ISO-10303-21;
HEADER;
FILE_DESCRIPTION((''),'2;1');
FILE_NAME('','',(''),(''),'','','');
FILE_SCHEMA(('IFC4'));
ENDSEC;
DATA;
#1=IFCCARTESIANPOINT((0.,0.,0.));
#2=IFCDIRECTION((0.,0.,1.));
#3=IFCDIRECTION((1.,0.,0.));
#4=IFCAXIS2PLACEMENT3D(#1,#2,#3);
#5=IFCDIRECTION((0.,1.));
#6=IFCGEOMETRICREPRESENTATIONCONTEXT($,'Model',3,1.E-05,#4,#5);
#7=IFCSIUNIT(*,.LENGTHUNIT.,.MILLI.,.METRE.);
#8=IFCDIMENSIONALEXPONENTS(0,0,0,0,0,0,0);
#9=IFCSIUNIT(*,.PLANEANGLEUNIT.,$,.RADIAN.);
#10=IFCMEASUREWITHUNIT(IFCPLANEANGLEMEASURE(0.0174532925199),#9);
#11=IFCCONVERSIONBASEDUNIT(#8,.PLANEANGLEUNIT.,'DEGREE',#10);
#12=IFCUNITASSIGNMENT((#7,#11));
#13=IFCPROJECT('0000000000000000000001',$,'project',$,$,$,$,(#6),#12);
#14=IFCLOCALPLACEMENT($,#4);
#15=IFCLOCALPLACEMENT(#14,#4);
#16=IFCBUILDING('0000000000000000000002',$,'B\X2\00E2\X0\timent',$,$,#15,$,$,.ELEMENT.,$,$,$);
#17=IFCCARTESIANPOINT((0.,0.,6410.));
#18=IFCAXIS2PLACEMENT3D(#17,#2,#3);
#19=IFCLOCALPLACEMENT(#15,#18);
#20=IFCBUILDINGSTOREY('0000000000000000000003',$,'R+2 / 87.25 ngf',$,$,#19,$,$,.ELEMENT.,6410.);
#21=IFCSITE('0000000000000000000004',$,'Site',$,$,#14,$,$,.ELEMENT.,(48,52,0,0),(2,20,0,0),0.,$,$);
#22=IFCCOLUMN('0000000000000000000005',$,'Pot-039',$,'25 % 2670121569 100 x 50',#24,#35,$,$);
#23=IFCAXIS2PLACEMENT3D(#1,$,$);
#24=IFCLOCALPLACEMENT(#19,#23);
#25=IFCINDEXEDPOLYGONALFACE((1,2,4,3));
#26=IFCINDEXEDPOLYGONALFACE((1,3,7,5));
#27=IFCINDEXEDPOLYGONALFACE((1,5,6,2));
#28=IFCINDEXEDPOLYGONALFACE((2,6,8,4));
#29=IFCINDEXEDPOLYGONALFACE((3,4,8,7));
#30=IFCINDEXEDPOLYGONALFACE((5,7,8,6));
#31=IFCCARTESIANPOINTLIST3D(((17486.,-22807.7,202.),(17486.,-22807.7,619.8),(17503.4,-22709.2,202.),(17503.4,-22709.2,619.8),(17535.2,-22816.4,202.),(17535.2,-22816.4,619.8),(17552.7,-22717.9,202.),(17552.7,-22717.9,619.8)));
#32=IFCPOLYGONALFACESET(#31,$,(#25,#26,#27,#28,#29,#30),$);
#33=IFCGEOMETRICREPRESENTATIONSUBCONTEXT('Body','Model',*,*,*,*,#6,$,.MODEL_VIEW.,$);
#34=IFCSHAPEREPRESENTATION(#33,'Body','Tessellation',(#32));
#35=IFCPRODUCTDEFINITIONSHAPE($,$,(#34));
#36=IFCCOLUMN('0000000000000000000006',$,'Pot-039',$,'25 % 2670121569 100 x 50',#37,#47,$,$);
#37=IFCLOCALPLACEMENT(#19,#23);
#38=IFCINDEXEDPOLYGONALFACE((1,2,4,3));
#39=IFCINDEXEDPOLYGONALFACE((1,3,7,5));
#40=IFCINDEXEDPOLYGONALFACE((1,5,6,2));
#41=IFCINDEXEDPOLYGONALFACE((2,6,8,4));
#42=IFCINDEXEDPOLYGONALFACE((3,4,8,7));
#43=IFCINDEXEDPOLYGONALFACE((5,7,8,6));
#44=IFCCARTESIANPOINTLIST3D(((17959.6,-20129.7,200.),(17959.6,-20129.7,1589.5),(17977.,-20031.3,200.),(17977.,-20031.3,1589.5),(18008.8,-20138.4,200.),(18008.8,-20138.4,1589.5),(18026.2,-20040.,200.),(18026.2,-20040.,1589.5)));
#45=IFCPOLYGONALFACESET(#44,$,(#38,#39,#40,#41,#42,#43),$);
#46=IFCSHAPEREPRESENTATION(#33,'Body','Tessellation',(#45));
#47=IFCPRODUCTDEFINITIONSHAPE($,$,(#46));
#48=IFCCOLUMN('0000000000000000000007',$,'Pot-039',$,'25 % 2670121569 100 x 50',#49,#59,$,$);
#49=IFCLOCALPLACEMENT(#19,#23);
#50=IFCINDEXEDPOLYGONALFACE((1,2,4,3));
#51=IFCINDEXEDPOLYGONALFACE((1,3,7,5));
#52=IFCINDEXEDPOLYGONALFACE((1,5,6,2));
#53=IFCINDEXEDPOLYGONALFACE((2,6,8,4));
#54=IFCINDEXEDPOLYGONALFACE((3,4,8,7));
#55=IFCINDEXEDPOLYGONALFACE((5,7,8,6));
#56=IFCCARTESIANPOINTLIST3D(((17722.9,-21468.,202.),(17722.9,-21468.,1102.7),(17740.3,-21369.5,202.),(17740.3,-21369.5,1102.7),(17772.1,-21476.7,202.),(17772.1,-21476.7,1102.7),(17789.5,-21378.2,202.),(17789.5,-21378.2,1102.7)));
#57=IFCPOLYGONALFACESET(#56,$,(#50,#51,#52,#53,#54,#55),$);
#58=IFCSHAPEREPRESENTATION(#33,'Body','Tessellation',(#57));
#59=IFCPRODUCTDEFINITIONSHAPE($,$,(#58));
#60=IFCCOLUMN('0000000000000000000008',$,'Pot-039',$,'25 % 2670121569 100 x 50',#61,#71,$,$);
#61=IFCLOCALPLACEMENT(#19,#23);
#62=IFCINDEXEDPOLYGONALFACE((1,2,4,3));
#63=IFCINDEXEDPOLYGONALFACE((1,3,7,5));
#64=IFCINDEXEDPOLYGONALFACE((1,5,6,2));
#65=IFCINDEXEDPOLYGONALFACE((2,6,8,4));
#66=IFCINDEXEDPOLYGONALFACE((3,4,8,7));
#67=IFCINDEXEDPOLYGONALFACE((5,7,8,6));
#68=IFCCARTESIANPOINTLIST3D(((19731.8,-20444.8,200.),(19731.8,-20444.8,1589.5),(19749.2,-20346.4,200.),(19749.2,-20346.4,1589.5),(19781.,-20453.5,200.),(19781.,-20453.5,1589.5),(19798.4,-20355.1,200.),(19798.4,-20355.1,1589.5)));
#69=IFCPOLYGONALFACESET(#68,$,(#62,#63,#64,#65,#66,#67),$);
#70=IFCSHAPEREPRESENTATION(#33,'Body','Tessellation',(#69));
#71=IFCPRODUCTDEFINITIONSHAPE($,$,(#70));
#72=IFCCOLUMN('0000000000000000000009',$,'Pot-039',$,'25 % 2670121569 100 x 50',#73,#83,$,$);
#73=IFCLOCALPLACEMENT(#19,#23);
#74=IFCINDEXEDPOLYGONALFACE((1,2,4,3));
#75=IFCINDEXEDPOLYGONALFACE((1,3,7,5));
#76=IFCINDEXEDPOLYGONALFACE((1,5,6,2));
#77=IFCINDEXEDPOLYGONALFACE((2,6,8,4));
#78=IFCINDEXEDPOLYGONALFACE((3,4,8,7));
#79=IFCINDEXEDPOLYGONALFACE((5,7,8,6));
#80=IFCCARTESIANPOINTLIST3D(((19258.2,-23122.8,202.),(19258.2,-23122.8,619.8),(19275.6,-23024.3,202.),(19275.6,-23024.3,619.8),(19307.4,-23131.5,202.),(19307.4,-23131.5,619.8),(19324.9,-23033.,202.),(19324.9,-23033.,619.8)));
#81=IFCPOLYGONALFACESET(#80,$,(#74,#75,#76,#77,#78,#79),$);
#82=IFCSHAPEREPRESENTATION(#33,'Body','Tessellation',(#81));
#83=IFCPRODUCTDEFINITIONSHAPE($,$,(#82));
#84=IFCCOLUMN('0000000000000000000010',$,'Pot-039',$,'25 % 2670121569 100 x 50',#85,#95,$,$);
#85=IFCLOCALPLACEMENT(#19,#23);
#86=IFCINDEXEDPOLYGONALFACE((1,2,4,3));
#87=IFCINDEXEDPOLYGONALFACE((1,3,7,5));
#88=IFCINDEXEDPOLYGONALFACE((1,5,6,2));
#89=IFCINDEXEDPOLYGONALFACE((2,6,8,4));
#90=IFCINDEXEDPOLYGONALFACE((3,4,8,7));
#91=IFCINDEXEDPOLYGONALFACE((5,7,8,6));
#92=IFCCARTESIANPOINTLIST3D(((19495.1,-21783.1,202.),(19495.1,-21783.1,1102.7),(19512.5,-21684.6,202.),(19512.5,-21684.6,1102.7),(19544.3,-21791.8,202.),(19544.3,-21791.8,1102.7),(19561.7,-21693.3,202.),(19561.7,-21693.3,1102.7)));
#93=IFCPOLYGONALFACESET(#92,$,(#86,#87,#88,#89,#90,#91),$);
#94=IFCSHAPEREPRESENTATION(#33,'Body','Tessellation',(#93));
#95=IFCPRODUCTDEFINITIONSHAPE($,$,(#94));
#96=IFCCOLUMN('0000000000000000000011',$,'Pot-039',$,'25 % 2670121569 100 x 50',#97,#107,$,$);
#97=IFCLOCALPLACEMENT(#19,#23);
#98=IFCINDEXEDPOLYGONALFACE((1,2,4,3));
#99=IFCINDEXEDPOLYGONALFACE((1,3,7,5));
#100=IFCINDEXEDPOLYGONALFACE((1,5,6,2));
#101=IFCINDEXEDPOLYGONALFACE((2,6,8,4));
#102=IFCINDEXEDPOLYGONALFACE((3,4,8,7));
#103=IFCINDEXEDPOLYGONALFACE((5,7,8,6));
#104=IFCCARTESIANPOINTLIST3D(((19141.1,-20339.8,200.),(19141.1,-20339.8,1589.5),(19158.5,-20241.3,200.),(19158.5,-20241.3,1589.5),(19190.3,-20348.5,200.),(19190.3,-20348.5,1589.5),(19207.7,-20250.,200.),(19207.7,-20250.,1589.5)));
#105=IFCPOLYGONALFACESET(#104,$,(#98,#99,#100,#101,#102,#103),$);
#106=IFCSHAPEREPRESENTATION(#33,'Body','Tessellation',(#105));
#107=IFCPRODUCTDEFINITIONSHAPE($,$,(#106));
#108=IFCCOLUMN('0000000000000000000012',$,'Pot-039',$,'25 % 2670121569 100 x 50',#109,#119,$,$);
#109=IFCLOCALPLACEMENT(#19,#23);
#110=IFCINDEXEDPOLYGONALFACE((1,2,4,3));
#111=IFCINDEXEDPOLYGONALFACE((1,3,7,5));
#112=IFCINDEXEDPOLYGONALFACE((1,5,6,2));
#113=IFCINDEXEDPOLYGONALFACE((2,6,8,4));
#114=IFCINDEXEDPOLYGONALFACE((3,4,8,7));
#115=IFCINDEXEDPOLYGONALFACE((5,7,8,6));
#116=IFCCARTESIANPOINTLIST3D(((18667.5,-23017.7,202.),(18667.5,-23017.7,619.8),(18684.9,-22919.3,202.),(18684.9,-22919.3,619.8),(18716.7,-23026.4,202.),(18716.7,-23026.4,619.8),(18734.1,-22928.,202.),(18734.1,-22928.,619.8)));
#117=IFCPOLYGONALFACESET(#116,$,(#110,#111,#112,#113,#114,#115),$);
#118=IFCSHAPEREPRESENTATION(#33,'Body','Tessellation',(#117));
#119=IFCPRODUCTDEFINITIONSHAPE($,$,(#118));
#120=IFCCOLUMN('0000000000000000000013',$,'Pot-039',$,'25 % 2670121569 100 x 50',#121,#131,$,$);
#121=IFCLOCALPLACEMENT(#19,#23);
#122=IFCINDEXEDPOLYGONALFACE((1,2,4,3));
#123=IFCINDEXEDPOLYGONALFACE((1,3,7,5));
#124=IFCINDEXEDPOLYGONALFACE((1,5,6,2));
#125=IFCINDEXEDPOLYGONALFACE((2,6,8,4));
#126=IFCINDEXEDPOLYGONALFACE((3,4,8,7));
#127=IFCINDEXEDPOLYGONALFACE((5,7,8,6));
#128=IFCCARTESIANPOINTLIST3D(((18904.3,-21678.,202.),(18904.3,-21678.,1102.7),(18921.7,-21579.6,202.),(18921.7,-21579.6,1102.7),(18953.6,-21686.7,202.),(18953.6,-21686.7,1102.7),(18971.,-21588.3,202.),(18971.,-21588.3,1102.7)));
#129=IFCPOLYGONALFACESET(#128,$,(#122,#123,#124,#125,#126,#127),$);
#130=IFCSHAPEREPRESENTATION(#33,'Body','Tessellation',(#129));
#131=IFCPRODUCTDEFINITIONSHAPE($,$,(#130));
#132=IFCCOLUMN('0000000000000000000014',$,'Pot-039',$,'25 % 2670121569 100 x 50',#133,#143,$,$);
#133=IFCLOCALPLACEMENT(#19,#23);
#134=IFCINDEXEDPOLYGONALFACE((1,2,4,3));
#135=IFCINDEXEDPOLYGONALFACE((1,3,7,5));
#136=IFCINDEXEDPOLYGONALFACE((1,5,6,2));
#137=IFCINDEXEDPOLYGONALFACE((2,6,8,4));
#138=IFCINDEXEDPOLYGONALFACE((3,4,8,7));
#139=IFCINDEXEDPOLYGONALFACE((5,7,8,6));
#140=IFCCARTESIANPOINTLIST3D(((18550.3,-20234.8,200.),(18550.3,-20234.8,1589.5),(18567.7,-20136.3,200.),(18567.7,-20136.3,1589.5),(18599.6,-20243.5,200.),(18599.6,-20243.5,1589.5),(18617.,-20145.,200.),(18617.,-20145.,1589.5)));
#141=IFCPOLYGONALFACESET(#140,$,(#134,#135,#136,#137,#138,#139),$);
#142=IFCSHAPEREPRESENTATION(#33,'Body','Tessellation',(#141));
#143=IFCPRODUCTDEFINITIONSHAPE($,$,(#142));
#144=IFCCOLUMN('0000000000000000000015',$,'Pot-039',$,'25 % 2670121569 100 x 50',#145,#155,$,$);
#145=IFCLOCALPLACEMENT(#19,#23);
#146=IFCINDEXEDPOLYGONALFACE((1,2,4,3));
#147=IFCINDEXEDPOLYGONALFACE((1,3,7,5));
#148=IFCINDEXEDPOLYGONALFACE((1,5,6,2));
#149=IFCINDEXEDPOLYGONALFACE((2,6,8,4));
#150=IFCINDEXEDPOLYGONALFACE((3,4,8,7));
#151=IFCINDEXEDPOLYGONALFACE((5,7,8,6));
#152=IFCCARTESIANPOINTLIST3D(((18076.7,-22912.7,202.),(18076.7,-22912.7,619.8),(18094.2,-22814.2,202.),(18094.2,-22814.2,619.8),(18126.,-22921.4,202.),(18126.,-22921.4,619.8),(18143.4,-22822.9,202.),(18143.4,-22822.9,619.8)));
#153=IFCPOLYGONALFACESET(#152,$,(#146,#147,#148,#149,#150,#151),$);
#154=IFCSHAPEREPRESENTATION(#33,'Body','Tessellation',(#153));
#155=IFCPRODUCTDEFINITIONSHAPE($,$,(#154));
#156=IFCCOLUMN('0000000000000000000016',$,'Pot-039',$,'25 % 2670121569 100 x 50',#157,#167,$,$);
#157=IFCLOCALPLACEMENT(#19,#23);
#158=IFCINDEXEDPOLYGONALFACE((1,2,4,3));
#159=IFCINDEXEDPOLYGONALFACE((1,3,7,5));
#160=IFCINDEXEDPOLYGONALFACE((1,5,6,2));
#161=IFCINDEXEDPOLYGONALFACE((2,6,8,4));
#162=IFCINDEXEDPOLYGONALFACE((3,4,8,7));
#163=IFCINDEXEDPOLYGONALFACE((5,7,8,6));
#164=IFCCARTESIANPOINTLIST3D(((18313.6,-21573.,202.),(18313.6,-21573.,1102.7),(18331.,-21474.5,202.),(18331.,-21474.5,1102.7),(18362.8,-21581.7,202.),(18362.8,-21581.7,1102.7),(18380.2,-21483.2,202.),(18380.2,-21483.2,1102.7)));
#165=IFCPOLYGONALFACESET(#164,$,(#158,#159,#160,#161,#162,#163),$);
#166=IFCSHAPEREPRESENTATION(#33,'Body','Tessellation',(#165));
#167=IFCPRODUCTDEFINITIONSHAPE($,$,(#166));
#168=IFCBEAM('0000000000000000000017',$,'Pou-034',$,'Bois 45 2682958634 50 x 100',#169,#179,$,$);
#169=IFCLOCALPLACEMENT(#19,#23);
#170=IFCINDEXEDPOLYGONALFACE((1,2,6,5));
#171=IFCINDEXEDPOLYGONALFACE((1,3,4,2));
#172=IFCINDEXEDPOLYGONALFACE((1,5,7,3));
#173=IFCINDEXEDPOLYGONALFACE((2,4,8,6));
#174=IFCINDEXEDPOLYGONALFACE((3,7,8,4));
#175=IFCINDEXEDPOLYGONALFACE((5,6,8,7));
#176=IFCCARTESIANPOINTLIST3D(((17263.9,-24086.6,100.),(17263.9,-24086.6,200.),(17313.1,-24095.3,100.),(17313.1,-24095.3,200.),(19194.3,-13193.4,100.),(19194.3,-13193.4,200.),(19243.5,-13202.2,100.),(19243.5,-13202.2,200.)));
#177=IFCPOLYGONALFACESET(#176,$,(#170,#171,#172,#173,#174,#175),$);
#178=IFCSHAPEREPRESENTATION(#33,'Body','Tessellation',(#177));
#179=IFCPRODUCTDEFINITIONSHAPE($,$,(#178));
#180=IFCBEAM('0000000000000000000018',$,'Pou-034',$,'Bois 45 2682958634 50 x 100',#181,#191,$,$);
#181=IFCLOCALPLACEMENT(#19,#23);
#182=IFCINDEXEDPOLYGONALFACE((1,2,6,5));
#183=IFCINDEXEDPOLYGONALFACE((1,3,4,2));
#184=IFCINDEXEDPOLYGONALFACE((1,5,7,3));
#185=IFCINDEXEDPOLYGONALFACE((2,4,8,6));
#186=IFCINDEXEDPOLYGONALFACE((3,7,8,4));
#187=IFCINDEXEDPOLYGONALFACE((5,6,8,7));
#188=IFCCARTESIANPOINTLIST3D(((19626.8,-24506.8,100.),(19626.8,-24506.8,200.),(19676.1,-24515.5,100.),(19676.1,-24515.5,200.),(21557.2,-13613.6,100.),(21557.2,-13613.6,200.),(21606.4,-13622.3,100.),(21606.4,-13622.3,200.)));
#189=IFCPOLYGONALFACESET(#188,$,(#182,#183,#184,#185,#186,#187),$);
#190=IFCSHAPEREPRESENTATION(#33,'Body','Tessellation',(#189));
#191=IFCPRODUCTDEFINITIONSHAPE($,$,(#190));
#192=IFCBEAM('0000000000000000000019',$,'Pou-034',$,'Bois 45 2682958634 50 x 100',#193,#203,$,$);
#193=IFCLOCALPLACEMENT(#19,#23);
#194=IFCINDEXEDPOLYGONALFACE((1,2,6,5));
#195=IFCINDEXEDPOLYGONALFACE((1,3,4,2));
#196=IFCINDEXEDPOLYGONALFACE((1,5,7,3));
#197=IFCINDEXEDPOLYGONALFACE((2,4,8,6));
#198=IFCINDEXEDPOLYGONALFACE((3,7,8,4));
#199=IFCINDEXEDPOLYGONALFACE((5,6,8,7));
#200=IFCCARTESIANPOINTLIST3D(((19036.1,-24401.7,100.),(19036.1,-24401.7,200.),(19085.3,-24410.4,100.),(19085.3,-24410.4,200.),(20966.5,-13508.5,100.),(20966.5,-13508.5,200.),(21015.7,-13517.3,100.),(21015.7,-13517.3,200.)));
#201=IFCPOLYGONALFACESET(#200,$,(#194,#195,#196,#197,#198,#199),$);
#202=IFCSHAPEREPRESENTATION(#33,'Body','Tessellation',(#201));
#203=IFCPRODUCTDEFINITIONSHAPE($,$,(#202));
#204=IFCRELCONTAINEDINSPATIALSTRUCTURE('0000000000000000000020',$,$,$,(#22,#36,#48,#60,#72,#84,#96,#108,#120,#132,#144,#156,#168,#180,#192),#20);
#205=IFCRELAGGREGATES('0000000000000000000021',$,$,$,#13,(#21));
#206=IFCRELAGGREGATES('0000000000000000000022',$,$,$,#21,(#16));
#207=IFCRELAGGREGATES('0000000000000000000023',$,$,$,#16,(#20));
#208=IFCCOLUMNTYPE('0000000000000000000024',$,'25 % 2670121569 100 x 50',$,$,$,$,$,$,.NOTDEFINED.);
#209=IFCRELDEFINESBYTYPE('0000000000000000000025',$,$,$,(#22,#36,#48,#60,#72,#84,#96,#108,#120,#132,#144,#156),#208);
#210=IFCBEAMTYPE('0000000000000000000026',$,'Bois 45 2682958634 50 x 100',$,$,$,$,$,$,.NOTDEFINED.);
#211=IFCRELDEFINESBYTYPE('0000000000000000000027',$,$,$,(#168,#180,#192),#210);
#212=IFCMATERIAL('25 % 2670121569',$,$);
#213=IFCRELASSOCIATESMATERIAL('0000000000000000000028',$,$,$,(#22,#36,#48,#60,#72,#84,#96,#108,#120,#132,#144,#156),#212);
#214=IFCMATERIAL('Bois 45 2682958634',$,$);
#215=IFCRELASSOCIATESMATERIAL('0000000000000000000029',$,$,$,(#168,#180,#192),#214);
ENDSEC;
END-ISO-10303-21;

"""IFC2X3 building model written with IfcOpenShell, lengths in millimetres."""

from ifc_helpers import new_model, entity, si_unit, converted_unit, direction, frame, frame_2d, origin_with_axes, origin_2d_with_axis, place, context, subcontext, project, spatial, rectangle, extrude, material, type_object, element, save


model = new_model("IFC2X3")

# Units and contexts
model_context = context("Model", 3, precision=1e-05, world=origin_with_axes(), true_north=direction((0.0, 1.0)))
body_context = subcontext(model_context, "Body", "Model", "MODEL_VIEW")
ifc_project = project(units=[si_unit("LENGTHUNIT", "METRE", prefix="MILLI"), converted_unit("PLANEANGLEUNIT", "DEGREE", entity("IfcPlaneAngleMeasure", 0.0174532925199), si_unit("PLANEANGLEUNIT", "RADIAN"), dimensions=[0, 0, 0, 0, 0, 0, 0])], contexts=[model_context])

# Site, building, storey
site_placement = place(None, origin_with_axes())
site = spatial("IfcSite", under=ifc_project, at=site_placement, Name="Site", CompositionType="ELEMENT", RefLatitude=(48, 52, 0, 0), RefLongitude=(2, 20, 0, 0), RefElevation=0.0)
building_placement = place(site_placement, origin_with_axes())
building = spatial("IfcBuilding", under=site, at=building_placement, Name="Bâtiment", CompositionType="ELEMENT")
storey_placement = place(building_placement, frame((0.0, 0.0, 6410.0), z_axis=(0.0, 0.0, 1.0), x_axis=(1.0, 0.0, 0.0)))
storey = spatial("IfcBuildingStorey", under=building, at=storey_placement, Name="R+2 / 87.25 ngf", CompositionType="ELEMENT", Elevation=6410.0)

# Columns
ifc_material_1 = material(Name="25 % 2670121569")
column_type = type_object("IfcColumnType", Name="25 % 2670121569 100 x 50", PredefinedType="NOTDEFINED")
column_1_placement = place(storey_placement, frame((17519.3, -22762.8, 202.0), z_axis=(0.0, 0.0, 1.0), x_axis=(0.17408, 0.984731, 0.0)))
element("IfcColumn", 1, at=column_1_placement, inside=storey, type_object=column_type, material=ifc_material_1, Name="Pot-039", ObjectType="25 % 2670121569 100 x 50", context=body_context, shape_type="SweptSolid", body=[
    extrude(rectangle(XDim=100.0, YDim=50.0, at=origin_2d_with_axis()), origin_with_axes(), (0.0, 0.0, 1.0), 417.8),
])
column_2_placement = place(storey_placement, frame((17992.9, -20084.9, 200.0), z_axis=(0.0, 0.0, 1.0), x_axis=(0.17408, 0.984731, 0.0)))
element("IfcColumn", 2, at=column_2_placement, inside=storey, type_object=column_type, material=ifc_material_1, Name="Pot-039", ObjectType="25 % 2670121569 100 x 50", context=body_context, shape_type="SweptSolid", body=[
    extrude(rectangle(XDim=100.0, YDim=50.0, at=origin_2d_with_axis()), origin_with_axes(), (0.0, 0.0, 1.0), 1389.5),
])
column_3_placement = place(storey_placement, frame((17756.2, -21423.1, 202.0), z_axis=(0.0, 0.0, 1.0), x_axis=(0.17408, 0.984731, 0.0)))
element("IfcColumn", 3, at=column_3_placement, inside=storey, type_object=column_type, material=ifc_material_1, Name="Pot-039", ObjectType="25 % 2670121569 100 x 50", context=body_context, shape_type="SweptSolid", body=[
    extrude(rectangle(XDim=100.0, YDim=50.0, at=origin_2d_with_axis()), origin_with_axes(), (0.0, 0.0, 1.0), 900.7),
])
column_4_placement = place(storey_placement, frame((19765.1, -20400.0, 200.0), z_axis=(0.0, 0.0, 1.0), x_axis=(0.17408, 0.984731, 0.0)))
element("IfcColumn", 4, at=column_4_placement, inside=storey, type_object=column_type, material=ifc_material_1, Name="Pot-039", ObjectType="25 % 2670121569 100 x 50", context=body_context, shape_type="SweptSolid", body=[
    extrude(rectangle(XDim=100.0, YDim=50.0, at=origin_2d_with_axis()), origin_with_axes(), (0.0, 0.0, 1.0), 1389.5),
])
column_5_placement = place(storey_placement, frame((19291.5, -23077.9, 202.0), z_axis=(0.0, 0.0, 1.0), x_axis=(0.17408, 0.984731, 0.0)))
element("IfcColumn", 5, at=column_5_placement, inside=storey, type_object=column_type, material=ifc_material_1, Name="Pot-039", ObjectType="25 % 2670121569 100 x 50", context=body_context, shape_type="SweptSolid", body=[
    extrude(rectangle(XDim=100.0, YDim=50.0, at=origin_2d_with_axis()), origin_with_axes(), (0.0, 0.0, 1.0), 417.8),
])
column_6_placement = place(storey_placement, frame((19528.4, -21738.2, 202.0), z_axis=(0.0, 0.0, 1.0), x_axis=(0.17408, 0.984731, 0.0)))
element("IfcColumn", 6, at=column_6_placement, inside=storey, type_object=column_type, material=ifc_material_1, Name="Pot-039", ObjectType="25 % 2670121569 100 x 50", context=body_context, shape_type="SweptSolid", body=[
    extrude(rectangle(XDim=100.0, YDim=50.0, at=origin_2d_with_axis()), origin_with_axes(), (0.0, 0.0, 1.0), 900.7),
])
column_7_placement = place(storey_placement, frame((19174.4, -20294.9, 200.0), z_axis=(0.0, 0.0, 1.0), x_axis=(0.17408, 0.984731, 0.0)))
element("IfcColumn", 7, at=column_7_placement, inside=storey, type_object=column_type, material=ifc_material_1, Name="Pot-039", ObjectType="25 % 2670121569 100 x 50", context=body_context, shape_type="SweptSolid", body=[
    extrude(rectangle(XDim=100.0, YDim=50.0, at=origin_2d_with_axis()), origin_with_axes(), (0.0, 0.0, 1.0), 1389.5),
])
column_8_placement = place(storey_placement, frame((18700.8, -22972.8, 202.0), z_axis=(0.0, 0.0, 1.0), x_axis=(0.17408, 0.984731, 0.0)))
element("IfcColumn", 8, at=column_8_placement, inside=storey, type_object=column_type, material=ifc_material_1, Name="Pot-039", ObjectType="25 % 2670121569 100 x 50", context=body_context, shape_type="SweptSolid", body=[
    extrude(rectangle(XDim=100.0, YDim=50.0, at=origin_2d_with_axis()), origin_with_axes(), (0.0, 0.0, 1.0), 417.8),
])
column_9_placement = place(storey_placement, frame((18937.6, -21633.1, 202.0), z_axis=(0.0, 0.0, 1.0), x_axis=(0.17408, 0.984731, 0.0)))
element("IfcColumn", 9, at=column_9_placement, inside=storey, type_object=column_type, material=ifc_material_1, Name="Pot-039", ObjectType="25 % 2670121569 100 x 50", context=body_context, shape_type="SweptSolid", body=[
    extrude(rectangle(XDim=100.0, YDim=50.0, at=origin_2d_with_axis()), origin_with_axes(), (0.0, 0.0, 1.0), 900.7),
])
column_10_placement = place(storey_placement, frame((18583.6, -20189.9, 200.0), z_axis=(0.0, 0.0, 1.0), x_axis=(0.17408, 0.984731, 0.0)))
element("IfcColumn", 10, at=column_10_placement, inside=storey, type_object=column_type, material=ifc_material_1, Name="Pot-039", ObjectType="25 % 2670121569 100 x 50", context=body_context, shape_type="SweptSolid", body=[
    extrude(rectangle(XDim=100.0, YDim=50.0, at=origin_2d_with_axis()), origin_with_axes(), (0.0, 0.0, 1.0), 1389.5),
])
column_11_placement = place(storey_placement, frame((18110.1, -22867.8, 202.0), z_axis=(0.0, 0.0, 1.0), x_axis=(0.17408, 0.984731, 0.0)))
element("IfcColumn", 11, at=column_11_placement, inside=storey, type_object=column_type, material=ifc_material_1, Name="Pot-039", ObjectType="25 % 2670121569 100 x 50", context=body_context, shape_type="SweptSolid", body=[
    extrude(rectangle(XDim=100.0, YDim=50.0, at=origin_2d_with_axis()), origin_with_axes(), (0.0, 0.0, 1.0), 417.8),
])
column_12_placement = place(storey_placement, frame((18346.9, -21528.1, 202.0), z_axis=(0.0, 0.0, 1.0), x_axis=(0.17408, 0.984731, 0.0)))
element("IfcColumn", 12, at=column_12_placement, inside=storey, type_object=column_type, material=ifc_material_1, Name="Pot-039", ObjectType="25 % 2670121569 100 x 50", context=body_context, shape_type="SweptSolid", body=[
    extrude(rectangle(XDim=100.0, YDim=50.0, at=origin_2d_with_axis()), origin_with_axes(), (0.0, 0.0, 1.0), 900.7),
])

# Beams
ifc_material_2 = material(Name="Bois 45 2682958634")
beam_type = type_object("IfcBeamType", Name="Bois 45 2682958634 50 x 100", PredefinedType="NOTDEFINED")
for number, where, z_axis, x_axis, name in (
    (13, (17288.5, -24091.0, 200.0), (0.0, 0.0, 1.0), (0.984659, -0.174492, 0.0), "Pou-034"),
    (14, (19651.4, -24511.1, 200.0), (0.0, 0.0, 1.0), (0.984659, -0.174492, 0.0), "Pou-034"),
    (15, (19060.7, -24406.1, 200.0), (0.0, 0.0, 1.0), (0.984659, -0.174492, 0.0), "Pou-034"),
):
    element("IfcBeam", number, at=place(storey_placement, frame(where, z_axis=z_axis, x_axis=x_axis)), inside=storey, type_object=beam_type, material=ifc_material_2, Name=name, ObjectType="Bois 45 2682958634 50 x 100", context=body_context, shape_type="SweptSolid", body=[
        extrude(rectangle(XDim=100.0, YDim=50.0, at=frame_2d((-50.0, 0.0), x_axis=(1.0, 0.0))), frame((0.0, 0.0, 0.0), z_axis=(0.0, 1.0, 0.0), x_axis=(0.0, 0.0, 1.0)), (0.0, 0.0, 1.0), 11062.9),
    ])

save(model, "model.ifc")
